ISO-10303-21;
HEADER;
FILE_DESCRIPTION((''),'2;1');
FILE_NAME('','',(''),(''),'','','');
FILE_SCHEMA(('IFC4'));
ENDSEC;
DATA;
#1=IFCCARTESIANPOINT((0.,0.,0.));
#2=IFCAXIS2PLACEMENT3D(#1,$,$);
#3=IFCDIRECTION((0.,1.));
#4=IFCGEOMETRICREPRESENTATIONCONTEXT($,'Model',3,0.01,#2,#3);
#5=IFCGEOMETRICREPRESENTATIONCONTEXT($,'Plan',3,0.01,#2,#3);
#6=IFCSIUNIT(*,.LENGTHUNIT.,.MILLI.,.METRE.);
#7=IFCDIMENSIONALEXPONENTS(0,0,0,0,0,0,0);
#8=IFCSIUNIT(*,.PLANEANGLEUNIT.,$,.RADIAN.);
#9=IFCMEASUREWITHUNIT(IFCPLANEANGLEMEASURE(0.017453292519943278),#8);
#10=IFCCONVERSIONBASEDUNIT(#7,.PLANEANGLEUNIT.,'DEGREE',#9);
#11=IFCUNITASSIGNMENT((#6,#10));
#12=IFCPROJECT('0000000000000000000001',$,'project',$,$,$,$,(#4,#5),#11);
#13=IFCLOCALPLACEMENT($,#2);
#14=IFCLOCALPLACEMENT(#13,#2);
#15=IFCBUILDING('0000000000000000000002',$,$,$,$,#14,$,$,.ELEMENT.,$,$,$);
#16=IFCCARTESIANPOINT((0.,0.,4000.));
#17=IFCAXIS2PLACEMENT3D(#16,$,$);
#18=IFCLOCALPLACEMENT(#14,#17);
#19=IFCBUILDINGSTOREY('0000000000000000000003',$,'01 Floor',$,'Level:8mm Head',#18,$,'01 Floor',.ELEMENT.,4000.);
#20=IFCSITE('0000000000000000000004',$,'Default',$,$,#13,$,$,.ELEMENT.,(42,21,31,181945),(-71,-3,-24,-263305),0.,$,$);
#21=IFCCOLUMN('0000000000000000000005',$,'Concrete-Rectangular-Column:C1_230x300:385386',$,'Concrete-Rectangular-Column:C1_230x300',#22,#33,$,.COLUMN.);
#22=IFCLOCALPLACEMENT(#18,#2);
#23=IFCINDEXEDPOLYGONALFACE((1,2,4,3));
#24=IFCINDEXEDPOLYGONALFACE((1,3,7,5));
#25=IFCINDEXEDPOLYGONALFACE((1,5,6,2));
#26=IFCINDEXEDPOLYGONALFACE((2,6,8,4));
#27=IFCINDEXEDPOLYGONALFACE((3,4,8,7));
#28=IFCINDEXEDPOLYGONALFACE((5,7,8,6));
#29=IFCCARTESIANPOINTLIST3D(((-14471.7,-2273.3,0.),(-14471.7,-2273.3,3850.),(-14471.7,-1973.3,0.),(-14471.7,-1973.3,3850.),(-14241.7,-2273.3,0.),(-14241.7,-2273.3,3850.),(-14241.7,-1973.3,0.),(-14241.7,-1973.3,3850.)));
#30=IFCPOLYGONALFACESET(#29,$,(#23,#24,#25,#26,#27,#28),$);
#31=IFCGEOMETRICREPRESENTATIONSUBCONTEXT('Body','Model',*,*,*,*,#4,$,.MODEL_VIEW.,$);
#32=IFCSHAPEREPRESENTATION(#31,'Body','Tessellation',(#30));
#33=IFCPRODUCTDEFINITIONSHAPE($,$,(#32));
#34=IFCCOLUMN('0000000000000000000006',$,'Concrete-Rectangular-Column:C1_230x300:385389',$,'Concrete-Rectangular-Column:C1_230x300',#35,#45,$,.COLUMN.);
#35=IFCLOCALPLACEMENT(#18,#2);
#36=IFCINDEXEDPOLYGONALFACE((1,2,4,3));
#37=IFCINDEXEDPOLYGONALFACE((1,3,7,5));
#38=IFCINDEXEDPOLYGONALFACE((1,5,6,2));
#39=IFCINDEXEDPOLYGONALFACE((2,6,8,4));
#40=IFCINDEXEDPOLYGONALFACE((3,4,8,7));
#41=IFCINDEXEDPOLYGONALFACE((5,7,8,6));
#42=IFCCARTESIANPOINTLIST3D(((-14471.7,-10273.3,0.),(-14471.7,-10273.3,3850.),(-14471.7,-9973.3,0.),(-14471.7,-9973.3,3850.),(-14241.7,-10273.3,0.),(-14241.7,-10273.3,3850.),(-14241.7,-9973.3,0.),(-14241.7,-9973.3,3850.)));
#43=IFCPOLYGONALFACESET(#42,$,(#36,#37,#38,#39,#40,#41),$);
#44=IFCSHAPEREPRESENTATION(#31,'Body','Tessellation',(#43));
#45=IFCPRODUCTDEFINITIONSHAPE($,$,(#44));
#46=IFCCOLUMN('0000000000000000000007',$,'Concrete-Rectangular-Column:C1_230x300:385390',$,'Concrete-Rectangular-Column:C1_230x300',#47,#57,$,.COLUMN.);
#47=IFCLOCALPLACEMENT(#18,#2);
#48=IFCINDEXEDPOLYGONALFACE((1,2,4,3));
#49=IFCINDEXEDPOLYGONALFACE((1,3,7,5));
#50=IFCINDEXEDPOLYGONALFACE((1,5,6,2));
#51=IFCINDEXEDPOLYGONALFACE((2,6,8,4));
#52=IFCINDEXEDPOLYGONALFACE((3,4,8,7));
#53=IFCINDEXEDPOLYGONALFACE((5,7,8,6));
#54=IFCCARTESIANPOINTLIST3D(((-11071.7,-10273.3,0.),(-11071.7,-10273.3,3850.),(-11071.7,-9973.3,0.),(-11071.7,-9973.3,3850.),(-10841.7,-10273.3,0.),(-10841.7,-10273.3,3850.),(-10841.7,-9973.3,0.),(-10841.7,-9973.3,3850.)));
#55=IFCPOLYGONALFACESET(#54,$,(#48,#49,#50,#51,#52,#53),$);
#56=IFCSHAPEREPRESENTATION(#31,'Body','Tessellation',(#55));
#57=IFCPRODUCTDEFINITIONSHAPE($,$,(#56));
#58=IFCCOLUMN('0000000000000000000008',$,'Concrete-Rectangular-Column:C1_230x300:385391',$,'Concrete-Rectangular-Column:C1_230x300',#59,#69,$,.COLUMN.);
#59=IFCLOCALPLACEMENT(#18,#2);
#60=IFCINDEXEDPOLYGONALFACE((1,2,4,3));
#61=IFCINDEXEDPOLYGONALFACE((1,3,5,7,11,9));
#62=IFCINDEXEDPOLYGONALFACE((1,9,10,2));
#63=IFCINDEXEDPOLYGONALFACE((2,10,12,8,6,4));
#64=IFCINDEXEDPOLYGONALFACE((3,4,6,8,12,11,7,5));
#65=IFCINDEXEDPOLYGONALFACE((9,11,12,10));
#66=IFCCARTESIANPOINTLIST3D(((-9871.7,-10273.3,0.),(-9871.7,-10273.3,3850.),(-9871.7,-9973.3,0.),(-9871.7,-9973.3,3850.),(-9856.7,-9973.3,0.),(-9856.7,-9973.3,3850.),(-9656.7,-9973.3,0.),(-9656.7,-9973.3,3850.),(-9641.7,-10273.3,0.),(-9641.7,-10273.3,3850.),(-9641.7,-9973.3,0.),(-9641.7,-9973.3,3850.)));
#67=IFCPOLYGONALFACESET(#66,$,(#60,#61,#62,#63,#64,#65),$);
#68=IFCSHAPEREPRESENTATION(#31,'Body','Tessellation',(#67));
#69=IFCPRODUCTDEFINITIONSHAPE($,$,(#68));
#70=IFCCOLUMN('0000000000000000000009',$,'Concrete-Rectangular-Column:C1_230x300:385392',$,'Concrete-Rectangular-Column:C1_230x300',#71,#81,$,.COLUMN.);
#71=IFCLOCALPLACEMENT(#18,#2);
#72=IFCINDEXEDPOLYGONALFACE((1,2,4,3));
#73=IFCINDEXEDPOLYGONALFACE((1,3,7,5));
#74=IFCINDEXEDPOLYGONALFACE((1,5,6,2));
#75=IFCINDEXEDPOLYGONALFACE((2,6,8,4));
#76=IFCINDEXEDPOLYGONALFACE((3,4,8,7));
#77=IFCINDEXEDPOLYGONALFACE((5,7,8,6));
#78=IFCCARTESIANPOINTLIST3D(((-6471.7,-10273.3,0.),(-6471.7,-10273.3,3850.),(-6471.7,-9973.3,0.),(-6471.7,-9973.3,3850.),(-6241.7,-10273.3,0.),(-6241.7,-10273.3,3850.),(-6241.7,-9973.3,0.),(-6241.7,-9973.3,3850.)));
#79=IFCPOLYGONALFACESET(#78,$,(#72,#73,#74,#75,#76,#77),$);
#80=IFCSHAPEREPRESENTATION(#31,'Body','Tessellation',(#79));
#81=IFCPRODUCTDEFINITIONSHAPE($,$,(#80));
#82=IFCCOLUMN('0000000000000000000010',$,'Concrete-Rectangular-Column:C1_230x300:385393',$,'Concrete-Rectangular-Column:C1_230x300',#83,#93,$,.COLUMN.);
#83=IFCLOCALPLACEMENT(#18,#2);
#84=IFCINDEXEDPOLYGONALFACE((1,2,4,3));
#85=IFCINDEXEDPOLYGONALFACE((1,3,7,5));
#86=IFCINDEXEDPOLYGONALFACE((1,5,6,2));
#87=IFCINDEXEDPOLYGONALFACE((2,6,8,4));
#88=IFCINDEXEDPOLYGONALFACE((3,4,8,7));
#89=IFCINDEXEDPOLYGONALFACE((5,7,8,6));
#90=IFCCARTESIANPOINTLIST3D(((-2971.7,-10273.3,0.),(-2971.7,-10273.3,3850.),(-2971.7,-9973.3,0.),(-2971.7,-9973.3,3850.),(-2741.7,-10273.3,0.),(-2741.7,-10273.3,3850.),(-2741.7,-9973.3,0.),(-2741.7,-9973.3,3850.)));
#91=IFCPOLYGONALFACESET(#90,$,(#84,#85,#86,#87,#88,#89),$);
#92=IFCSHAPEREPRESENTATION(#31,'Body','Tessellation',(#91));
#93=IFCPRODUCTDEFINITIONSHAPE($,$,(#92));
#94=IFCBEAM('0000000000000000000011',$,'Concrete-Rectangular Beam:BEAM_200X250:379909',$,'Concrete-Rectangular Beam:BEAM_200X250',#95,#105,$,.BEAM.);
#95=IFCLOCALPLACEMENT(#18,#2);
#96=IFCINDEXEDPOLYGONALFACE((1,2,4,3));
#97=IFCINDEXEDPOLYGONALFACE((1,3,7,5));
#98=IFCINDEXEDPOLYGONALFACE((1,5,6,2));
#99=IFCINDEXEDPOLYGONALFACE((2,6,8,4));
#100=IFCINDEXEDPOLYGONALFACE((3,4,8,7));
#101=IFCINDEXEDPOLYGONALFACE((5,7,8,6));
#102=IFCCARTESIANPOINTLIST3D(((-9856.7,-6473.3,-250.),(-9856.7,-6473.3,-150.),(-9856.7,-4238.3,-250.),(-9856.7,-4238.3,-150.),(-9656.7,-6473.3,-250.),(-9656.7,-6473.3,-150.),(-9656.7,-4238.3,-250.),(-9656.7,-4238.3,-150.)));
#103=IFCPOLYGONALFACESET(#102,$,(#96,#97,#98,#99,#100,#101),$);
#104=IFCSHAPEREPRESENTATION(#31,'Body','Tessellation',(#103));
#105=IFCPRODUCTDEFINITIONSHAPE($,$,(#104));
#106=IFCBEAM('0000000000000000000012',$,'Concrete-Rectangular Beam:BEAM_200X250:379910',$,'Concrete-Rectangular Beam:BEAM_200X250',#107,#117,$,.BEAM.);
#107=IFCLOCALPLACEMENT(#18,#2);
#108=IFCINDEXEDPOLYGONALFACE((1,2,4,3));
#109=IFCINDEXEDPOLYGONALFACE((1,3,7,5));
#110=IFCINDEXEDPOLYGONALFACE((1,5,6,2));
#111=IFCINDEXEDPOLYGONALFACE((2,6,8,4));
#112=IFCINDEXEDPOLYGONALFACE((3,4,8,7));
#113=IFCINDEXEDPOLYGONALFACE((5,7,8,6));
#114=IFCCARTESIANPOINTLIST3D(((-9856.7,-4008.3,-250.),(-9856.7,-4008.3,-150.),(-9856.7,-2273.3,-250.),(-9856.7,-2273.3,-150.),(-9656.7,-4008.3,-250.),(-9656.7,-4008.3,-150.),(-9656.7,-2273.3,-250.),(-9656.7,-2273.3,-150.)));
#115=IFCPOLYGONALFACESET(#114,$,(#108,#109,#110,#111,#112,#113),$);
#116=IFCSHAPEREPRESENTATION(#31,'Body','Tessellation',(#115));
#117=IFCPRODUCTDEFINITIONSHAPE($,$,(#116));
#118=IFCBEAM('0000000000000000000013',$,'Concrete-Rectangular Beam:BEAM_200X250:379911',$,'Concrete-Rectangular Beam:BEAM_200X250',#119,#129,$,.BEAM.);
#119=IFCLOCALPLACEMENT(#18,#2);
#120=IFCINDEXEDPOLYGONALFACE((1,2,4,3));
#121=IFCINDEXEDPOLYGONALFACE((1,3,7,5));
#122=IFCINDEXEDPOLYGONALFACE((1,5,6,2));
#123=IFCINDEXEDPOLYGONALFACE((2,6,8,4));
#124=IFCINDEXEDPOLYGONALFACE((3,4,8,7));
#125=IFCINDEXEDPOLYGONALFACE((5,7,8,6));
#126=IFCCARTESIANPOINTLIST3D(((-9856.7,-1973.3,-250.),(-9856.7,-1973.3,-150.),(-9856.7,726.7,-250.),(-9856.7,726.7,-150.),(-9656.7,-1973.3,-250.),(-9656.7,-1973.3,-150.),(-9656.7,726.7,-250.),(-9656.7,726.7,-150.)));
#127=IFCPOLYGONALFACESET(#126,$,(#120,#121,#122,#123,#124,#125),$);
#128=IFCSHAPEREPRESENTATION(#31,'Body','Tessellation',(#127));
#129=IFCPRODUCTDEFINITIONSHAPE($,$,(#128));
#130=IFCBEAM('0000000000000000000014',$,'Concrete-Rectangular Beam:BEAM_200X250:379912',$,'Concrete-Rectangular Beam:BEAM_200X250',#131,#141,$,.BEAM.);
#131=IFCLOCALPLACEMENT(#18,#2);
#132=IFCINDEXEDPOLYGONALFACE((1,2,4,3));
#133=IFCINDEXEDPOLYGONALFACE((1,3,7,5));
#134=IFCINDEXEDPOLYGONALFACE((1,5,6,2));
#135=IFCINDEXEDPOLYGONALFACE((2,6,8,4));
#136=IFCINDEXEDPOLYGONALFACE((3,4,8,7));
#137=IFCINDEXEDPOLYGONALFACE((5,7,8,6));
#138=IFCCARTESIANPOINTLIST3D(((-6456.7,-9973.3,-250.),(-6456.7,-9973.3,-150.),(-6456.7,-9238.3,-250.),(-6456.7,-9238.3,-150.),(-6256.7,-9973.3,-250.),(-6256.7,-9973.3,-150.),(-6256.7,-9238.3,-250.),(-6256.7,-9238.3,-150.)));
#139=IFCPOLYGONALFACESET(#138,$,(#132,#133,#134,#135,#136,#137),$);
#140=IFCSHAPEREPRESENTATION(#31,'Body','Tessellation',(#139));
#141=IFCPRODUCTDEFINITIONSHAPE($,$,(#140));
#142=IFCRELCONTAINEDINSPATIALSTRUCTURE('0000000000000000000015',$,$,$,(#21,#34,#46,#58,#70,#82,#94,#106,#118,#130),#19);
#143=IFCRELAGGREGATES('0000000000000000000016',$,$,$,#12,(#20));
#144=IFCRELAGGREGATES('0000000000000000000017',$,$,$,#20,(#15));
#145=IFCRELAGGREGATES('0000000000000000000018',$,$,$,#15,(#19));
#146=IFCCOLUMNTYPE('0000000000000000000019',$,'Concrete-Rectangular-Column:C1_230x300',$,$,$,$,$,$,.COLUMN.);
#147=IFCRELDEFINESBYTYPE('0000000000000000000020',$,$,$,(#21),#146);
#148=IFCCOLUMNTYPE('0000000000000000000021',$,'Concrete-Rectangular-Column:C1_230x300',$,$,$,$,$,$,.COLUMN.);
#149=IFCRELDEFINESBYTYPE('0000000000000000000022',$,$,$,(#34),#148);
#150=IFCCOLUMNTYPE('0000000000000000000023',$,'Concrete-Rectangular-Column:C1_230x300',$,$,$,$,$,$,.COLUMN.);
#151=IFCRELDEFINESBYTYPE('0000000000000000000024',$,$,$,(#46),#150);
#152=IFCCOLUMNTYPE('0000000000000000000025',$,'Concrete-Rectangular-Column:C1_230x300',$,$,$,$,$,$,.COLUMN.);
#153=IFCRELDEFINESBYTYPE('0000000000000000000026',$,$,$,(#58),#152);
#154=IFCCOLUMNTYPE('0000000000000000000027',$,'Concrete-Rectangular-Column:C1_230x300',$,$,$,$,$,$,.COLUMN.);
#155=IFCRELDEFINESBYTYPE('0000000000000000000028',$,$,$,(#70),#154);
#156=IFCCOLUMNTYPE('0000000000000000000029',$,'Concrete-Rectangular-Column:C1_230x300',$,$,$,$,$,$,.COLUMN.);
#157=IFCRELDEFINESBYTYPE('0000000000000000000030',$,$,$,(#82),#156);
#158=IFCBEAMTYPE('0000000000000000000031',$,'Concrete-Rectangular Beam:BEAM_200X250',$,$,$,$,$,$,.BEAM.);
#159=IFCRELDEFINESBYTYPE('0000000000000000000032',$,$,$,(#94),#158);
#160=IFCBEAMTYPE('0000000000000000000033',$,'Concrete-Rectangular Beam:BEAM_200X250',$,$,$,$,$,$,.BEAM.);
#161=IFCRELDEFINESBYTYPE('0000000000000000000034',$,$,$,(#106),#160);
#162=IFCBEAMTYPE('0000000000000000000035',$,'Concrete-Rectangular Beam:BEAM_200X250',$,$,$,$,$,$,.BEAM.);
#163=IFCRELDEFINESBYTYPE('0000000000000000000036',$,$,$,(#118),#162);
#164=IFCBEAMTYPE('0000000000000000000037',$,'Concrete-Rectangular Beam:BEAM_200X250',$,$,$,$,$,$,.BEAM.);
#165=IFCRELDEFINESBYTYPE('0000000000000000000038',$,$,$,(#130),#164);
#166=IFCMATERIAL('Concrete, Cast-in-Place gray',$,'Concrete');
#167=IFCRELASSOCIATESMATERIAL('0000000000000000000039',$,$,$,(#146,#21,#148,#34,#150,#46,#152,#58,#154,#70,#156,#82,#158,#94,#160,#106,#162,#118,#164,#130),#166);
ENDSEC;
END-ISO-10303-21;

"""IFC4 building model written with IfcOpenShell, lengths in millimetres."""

from ifc_helpers import new_model, entity, si_unit, converted_unit, direction, frame, origin, place, context, subcontext, project, spatial, indexed_curve, outline, extrude, source, transform, mapped, material, type_object, type_shapes, element, save


model = new_model("IFC4")

# Units and contexts
model_context = context("Model", 3, precision=0.01, world=origin(), true_north=direction((0.0, 1.0)))
plan_context = context("Plan", 3, precision=0.01, world=origin(), true_north=direction((0.0, 1.0)))
body_context = subcontext(model_context, "Body", "Model", "MODEL_VIEW")
ifc_project = project(units=[si_unit("LENGTHUNIT", "METRE", prefix="MILLI"), converted_unit("PLANEANGLEUNIT", "DEGREE", entity("IfcPlaneAngleMeasure", 0.017453292519943278), si_unit("PLANEANGLEUNIT", "RADIAN"), dimensions=[0, 0, 0, 0, 0, 0, 0])], contexts=[model_context, plan_context])

# Site, building, storey
site_placement = place(None, origin())
site = spatial("IfcSite", under=ifc_project, at=site_placement, Name="Default", CompositionType="ELEMENT", RefLatitude=(42, 21, 31, 181945), RefLongitude=(-71, -3, -24, -263305), RefElevation=0.0)
building_placement = place(site_placement, origin())
building = spatial("IfcBuilding", under=site, at=building_placement, CompositionType="ELEMENT")
storey_placement = place(building_placement, frame((0.0, 0.0, 4000.0)))
storey = spatial("IfcBuildingStorey", under=building, at=storey_placement, Name="01 Floor", ObjectType="Level:8mm Head", LongName="01 Floor", CompositionType="ELEMENT", Elevation=4000.0)

# Columns
ifc_material = material(Name="Concrete, Cast-in-Place gray", Category="Concrete")
column_type_1 = type_object("IfcColumnType", Name="Concrete-Rectangular-Column:C1_230x300", PredefinedType="COLUMN", material=ifc_material)
shared_shape_1 = source(origin(), body_context, "Body", "SweptSolid", [
    extrude(outline(indexed_curve([(-115.0, -150.0), (115.0, -150.0), (115.0, 150.0), (-115.0, 150.0), (-115.0, -150.0)], self_intersect=False)), frame((-14356.7, -2123.3, 4000.0), z_axis=(0.0, 0.0, 1.0), x_axis=(-1.0, 0.0, 0.0)), (0.0, 0.0, 1.0), 3850.0),
])
type_shapes(column_type_1, [shared_shape_1])
column_1_placement = place(storey_placement, frame((0.0, 0.0, -4000.0)))
element("IfcColumn", 1, at=column_1_placement, inside=storey, type_object=column_type_1, material=ifc_material, Name="Concrete-Rectangular-Column:C1_230x300:385386", ObjectType="Concrete-Rectangular-Column:C1_230x300", PredefinedType="COLUMN", context=body_context, shape_type="MappedRepresentation", body=[
    mapped(shared_shape_1, transform((0.0, 0.0, 0.0), scale=1.0)),
])
column_type_2 = type_object("IfcColumnType", Name="Concrete-Rectangular-Column:C1_230x300", PredefinedType="COLUMN", material=ifc_material)
shared_shape_2 = source(origin(), body_context, "Body", "SweptSolid", [
    extrude(outline(indexed_curve([(-115.0, -150.0), (115.0, -150.0), (115.0, 150.0), (-115.0, 150.0), (-115.0, -150.0)], self_intersect=False)), frame((-14356.7, -10123.3, 4000.0)), (0.0, 0.0, 1.0), 3850.0),
])
type_shapes(column_type_2, [shared_shape_2])
column_2_placement = place(storey_placement, frame((0.0, 0.0, -4000.0)))
element("IfcColumn", 2, at=column_2_placement, inside=storey, type_object=column_type_2, material=ifc_material, Name="Concrete-Rectangular-Column:C1_230x300:385389", ObjectType="Concrete-Rectangular-Column:C1_230x300", PredefinedType="COLUMN", context=body_context, shape_type="MappedRepresentation", body=[
    mapped(shared_shape_2, transform((0.0, 0.0, 0.0), scale=1.0)),
])
column_type_3 = type_object("IfcColumnType", Name="Concrete-Rectangular-Column:C1_230x300", PredefinedType="COLUMN", material=ifc_material)
shared_shape_3 = source(origin(), body_context, "Body", "SweptSolid", [
    extrude(outline(indexed_curve([(-115.0, -150.0), (115.0, -150.0), (115.0, 150.0), (-115.0, 150.0), (-115.0, -150.0)], self_intersect=False)), frame((-10956.7, -10123.3, 4000.0), z_axis=(0.0, 0.0, 1.0), x_axis=(-1.0, 0.0, 0.0)), (0.0, 0.0, 1.0), 3850.0),
])
type_shapes(column_type_3, [shared_shape_3])
column_3_placement = place(storey_placement, frame((0.0, 0.0, -4000.0)))
element("IfcColumn", 3, at=column_3_placement, inside=storey, type_object=column_type_3, material=ifc_material, Name="Concrete-Rectangular-Column:C1_230x300:385390", ObjectType="Concrete-Rectangular-Column:C1_230x300", PredefinedType="COLUMN", context=body_context, shape_type="MappedRepresentation", body=[
    mapped(shared_shape_3, transform((0.0, 0.0, 0.0), scale=1.0)),
])
column_type_4 = type_object("IfcColumnType", Name="Concrete-Rectangular-Column:C1_230x300", PredefinedType="COLUMN", material=ifc_material)
shared_shape_4 = source(origin(), body_context, "Body", "SweptSolid", [
    extrude(outline(indexed_curve([(-115.0, -200.0), (115.0, -200.0), (115.0, 100.0), (100.0, 100.0), (-100.0, 100.0), (-115.0, 100.0), (-115.0, -200.0)], self_intersect=False)), frame((-9756.7, -10073.3, 4000.0)), (0.0, 0.0, 1.0), 3850.0),
])
type_shapes(column_type_4, [shared_shape_4])
column_4_placement = place(storey_placement, frame((0.0, 0.0, -4000.0)))
element("IfcColumn", 4, at=column_4_placement, inside=storey, type_object=column_type_4, material=ifc_material, Name="Concrete-Rectangular-Column:C1_230x300:385391", ObjectType="Concrete-Rectangular-Column:C1_230x300", PredefinedType="COLUMN", context=body_context, shape_type="MappedRepresentation", body=[
    mapped(shared_shape_4, transform((0.0, 0.0, 0.0), scale=1.0)),
])
column_type_5 = type_object("IfcColumnType", Name="Concrete-Rectangular-Column:C1_230x300", PredefinedType="COLUMN", material=ifc_material)
shared_shape_5 = source(origin(), body_context, "Body", "SweptSolid", [
    extrude(outline(indexed_curve([(-115.0, -150.0), (115.0, -150.0), (115.0, 150.0), (-115.0, 150.0), (-115.0, -150.0)], self_intersect=False)), frame((-6356.7, -10123.3, 4000.0)), (0.0, 0.0, 1.0), 3850.0),
])
type_shapes(column_type_5, [shared_shape_5])
column_5_placement = place(storey_placement, frame((0.0, 0.0, -4000.0)))
element("IfcColumn", 5, at=column_5_placement, inside=storey, type_object=column_type_5, material=ifc_material, Name="Concrete-Rectangular-Column:C1_230x300:385392", ObjectType="Concrete-Rectangular-Column:C1_230x300", PredefinedType="COLUMN", context=body_context, shape_type="MappedRepresentation", body=[
    mapped(shared_shape_5, transform((0.0, 0.0, 0.0), scale=1.0)),
])
column_type_6 = type_object("IfcColumnType", Name="Concrete-Rectangular-Column:C1_230x300", PredefinedType="COLUMN", material=ifc_material)
shared_shape_6 = source(origin(), body_context, "Body", "SweptSolid", [
    extrude(outline(indexed_curve([(-115.0, -150.0), (115.0, -150.0), (115.0, 150.0), (-115.0, 150.0), (-115.0, -150.0)], self_intersect=False)), frame((-2856.7, -10123.3, 4000.0), z_axis=(0.0, 0.0, 1.0), x_axis=(-1.0, 0.0, 0.0)), (0.0, 0.0, 1.0), 3850.0),
])
type_shapes(column_type_6, [shared_shape_6])
column_6_placement = place(storey_placement, frame((0.0, 0.0, -4000.0)))
element("IfcColumn", 6, at=column_6_placement, inside=storey, type_object=column_type_6, material=ifc_material, Name="Concrete-Rectangular-Column:C1_230x300:385393", ObjectType="Concrete-Rectangular-Column:C1_230x300", PredefinedType="COLUMN", context=body_context, shape_type="MappedRepresentation", body=[
    mapped(shared_shape_6, transform((0.0, 0.0, 0.0), scale=1.0)),
])

# Beams
beam_type_1 = type_object("IfcBeamType", Name="Concrete-Rectangular Beam:BEAM_200X250", PredefinedType="BEAM", material=ifc_material)
shared_shape_7 = source(origin(), body_context, "Body", "SweptSolid", [
    extrude(outline(indexed_curve([(-100.0, -50.0), (100.0, -50.0), (100.0, 50.0), (-100.0, 50.0), (-100.0, -50.0)], self_intersect=False)), frame((-9756.7, -6473.3, 3800.0), z_axis=(0.0, 1.0, 0.0), x_axis=(-1.0, 0.0, 0.0)), (0.0, 0.0, 1.0), 2235.0),
])
type_shapes(beam_type_1, [shared_shape_7])
beam_1_placement = place(storey_placement, frame((0.0, 0.0, -4000.0)))
element("IfcBeam", 7, at=beam_1_placement, inside=storey, type_object=beam_type_1, material=ifc_material, Name="Concrete-Rectangular Beam:BEAM_200X250:379909", ObjectType="Concrete-Rectangular Beam:BEAM_200X250", PredefinedType="BEAM", context=body_context, shape_type="MappedRepresentation", body=[
    mapped(shared_shape_7, transform((0.0, 0.0, 0.0), scale=1.0)),
])
beam_type_2 = type_object("IfcBeamType", Name="Concrete-Rectangular Beam:BEAM_200X250", PredefinedType="BEAM", material=ifc_material)
shared_shape_8 = source(origin(), body_context, "Body", "SweptSolid", [
    extrude(outline(indexed_curve([(-100.0, -50.0), (100.0, -50.0), (100.0, 50.0), (-100.0, 50.0), (-100.0, -50.0)], self_intersect=False)), frame((-9756.7, -4008.3, 3800.0), z_axis=(0.0, 1.0, 0.0), x_axis=(-1.0, 0.0, 0.0)), (0.0, 0.0, 1.0), 1735.0),
])
type_shapes(beam_type_2, [shared_shape_8])
beam_2_placement = place(storey_placement, frame((0.0, 0.0, -4000.0)))
element("IfcBeam", 8, at=beam_2_placement, inside=storey, type_object=beam_type_2, material=ifc_material, Name="Concrete-Rectangular Beam:BEAM_200X250:379910", ObjectType="Concrete-Rectangular Beam:BEAM_200X250", PredefinedType="BEAM", context=body_context, shape_type="MappedRepresentation", body=[
    mapped(shared_shape_8, transform((0.0, 0.0, 0.0), scale=1.0)),
])
beam_type_3 = type_object("IfcBeamType", Name="Concrete-Rectangular Beam:BEAM_200X250", PredefinedType="BEAM", material=ifc_material)
shared_shape_9 = source(origin(), body_context, "Body", "SweptSolid", [
    extrude(outline(indexed_curve([(-100.0, -50.0), (100.0, -50.0), (100.0, 50.0), (-100.0, 50.0), (-100.0, -50.0)], self_intersect=False)), frame((-9756.7, -1973.3, 3800.0), z_axis=(0.0, 1.0, 0.0), x_axis=(-1.0, 0.0, 0.0)), (0.0, 0.0, 1.0), 2700.0),
])
type_shapes(beam_type_3, [shared_shape_9])
beam_3_placement = place(storey_placement, frame((0.0, 0.0, -4000.0)))
element("IfcBeam", 9, at=beam_3_placement, inside=storey, type_object=beam_type_3, material=ifc_material, Name="Concrete-Rectangular Beam:BEAM_200X250:379911", ObjectType="Concrete-Rectangular Beam:BEAM_200X250", PredefinedType="BEAM", context=body_context, shape_type="MappedRepresentation", body=[
    mapped(shared_shape_9, transform((0.0, 0.0, 0.0), scale=1.0)),
])
beam_type_4 = type_object("IfcBeamType", Name="Concrete-Rectangular Beam:BEAM_200X250", PredefinedType="BEAM", material=ifc_material)
shared_shape_10 = source(origin(), body_context, "Body", "SweptSolid", [
    extrude(outline(indexed_curve([(-100.0, -50.0), (100.0, -50.0), (100.0, 50.0), (-100.0, 50.0), (-100.0, -50.0)], self_intersect=False)), frame((-6356.7, -9973.3, 3800.0), z_axis=(0.0, 1.0, 0.0), x_axis=(-1.0, 0.0, 0.0)), (0.0, 0.0, 1.0), 735.0),
])
type_shapes(beam_type_4, [shared_shape_10])
beam_4_placement = place(storey_placement, frame((0.0, 0.0, -4000.0)))
element("IfcBeam", 10, at=beam_4_placement, inside=storey, type_object=beam_type_4, material=ifc_material, Name="Concrete-Rectangular Beam:BEAM_200X250:379912", ObjectType="Concrete-Rectangular Beam:BEAM_200X250", PredefinedType="BEAM", context=body_context, shape_type="MappedRepresentation", body=[
    mapped(shared_shape_10, transform((0.0, 0.0, 0.0), scale=1.0)),
])

save(model, "model.ifc")
